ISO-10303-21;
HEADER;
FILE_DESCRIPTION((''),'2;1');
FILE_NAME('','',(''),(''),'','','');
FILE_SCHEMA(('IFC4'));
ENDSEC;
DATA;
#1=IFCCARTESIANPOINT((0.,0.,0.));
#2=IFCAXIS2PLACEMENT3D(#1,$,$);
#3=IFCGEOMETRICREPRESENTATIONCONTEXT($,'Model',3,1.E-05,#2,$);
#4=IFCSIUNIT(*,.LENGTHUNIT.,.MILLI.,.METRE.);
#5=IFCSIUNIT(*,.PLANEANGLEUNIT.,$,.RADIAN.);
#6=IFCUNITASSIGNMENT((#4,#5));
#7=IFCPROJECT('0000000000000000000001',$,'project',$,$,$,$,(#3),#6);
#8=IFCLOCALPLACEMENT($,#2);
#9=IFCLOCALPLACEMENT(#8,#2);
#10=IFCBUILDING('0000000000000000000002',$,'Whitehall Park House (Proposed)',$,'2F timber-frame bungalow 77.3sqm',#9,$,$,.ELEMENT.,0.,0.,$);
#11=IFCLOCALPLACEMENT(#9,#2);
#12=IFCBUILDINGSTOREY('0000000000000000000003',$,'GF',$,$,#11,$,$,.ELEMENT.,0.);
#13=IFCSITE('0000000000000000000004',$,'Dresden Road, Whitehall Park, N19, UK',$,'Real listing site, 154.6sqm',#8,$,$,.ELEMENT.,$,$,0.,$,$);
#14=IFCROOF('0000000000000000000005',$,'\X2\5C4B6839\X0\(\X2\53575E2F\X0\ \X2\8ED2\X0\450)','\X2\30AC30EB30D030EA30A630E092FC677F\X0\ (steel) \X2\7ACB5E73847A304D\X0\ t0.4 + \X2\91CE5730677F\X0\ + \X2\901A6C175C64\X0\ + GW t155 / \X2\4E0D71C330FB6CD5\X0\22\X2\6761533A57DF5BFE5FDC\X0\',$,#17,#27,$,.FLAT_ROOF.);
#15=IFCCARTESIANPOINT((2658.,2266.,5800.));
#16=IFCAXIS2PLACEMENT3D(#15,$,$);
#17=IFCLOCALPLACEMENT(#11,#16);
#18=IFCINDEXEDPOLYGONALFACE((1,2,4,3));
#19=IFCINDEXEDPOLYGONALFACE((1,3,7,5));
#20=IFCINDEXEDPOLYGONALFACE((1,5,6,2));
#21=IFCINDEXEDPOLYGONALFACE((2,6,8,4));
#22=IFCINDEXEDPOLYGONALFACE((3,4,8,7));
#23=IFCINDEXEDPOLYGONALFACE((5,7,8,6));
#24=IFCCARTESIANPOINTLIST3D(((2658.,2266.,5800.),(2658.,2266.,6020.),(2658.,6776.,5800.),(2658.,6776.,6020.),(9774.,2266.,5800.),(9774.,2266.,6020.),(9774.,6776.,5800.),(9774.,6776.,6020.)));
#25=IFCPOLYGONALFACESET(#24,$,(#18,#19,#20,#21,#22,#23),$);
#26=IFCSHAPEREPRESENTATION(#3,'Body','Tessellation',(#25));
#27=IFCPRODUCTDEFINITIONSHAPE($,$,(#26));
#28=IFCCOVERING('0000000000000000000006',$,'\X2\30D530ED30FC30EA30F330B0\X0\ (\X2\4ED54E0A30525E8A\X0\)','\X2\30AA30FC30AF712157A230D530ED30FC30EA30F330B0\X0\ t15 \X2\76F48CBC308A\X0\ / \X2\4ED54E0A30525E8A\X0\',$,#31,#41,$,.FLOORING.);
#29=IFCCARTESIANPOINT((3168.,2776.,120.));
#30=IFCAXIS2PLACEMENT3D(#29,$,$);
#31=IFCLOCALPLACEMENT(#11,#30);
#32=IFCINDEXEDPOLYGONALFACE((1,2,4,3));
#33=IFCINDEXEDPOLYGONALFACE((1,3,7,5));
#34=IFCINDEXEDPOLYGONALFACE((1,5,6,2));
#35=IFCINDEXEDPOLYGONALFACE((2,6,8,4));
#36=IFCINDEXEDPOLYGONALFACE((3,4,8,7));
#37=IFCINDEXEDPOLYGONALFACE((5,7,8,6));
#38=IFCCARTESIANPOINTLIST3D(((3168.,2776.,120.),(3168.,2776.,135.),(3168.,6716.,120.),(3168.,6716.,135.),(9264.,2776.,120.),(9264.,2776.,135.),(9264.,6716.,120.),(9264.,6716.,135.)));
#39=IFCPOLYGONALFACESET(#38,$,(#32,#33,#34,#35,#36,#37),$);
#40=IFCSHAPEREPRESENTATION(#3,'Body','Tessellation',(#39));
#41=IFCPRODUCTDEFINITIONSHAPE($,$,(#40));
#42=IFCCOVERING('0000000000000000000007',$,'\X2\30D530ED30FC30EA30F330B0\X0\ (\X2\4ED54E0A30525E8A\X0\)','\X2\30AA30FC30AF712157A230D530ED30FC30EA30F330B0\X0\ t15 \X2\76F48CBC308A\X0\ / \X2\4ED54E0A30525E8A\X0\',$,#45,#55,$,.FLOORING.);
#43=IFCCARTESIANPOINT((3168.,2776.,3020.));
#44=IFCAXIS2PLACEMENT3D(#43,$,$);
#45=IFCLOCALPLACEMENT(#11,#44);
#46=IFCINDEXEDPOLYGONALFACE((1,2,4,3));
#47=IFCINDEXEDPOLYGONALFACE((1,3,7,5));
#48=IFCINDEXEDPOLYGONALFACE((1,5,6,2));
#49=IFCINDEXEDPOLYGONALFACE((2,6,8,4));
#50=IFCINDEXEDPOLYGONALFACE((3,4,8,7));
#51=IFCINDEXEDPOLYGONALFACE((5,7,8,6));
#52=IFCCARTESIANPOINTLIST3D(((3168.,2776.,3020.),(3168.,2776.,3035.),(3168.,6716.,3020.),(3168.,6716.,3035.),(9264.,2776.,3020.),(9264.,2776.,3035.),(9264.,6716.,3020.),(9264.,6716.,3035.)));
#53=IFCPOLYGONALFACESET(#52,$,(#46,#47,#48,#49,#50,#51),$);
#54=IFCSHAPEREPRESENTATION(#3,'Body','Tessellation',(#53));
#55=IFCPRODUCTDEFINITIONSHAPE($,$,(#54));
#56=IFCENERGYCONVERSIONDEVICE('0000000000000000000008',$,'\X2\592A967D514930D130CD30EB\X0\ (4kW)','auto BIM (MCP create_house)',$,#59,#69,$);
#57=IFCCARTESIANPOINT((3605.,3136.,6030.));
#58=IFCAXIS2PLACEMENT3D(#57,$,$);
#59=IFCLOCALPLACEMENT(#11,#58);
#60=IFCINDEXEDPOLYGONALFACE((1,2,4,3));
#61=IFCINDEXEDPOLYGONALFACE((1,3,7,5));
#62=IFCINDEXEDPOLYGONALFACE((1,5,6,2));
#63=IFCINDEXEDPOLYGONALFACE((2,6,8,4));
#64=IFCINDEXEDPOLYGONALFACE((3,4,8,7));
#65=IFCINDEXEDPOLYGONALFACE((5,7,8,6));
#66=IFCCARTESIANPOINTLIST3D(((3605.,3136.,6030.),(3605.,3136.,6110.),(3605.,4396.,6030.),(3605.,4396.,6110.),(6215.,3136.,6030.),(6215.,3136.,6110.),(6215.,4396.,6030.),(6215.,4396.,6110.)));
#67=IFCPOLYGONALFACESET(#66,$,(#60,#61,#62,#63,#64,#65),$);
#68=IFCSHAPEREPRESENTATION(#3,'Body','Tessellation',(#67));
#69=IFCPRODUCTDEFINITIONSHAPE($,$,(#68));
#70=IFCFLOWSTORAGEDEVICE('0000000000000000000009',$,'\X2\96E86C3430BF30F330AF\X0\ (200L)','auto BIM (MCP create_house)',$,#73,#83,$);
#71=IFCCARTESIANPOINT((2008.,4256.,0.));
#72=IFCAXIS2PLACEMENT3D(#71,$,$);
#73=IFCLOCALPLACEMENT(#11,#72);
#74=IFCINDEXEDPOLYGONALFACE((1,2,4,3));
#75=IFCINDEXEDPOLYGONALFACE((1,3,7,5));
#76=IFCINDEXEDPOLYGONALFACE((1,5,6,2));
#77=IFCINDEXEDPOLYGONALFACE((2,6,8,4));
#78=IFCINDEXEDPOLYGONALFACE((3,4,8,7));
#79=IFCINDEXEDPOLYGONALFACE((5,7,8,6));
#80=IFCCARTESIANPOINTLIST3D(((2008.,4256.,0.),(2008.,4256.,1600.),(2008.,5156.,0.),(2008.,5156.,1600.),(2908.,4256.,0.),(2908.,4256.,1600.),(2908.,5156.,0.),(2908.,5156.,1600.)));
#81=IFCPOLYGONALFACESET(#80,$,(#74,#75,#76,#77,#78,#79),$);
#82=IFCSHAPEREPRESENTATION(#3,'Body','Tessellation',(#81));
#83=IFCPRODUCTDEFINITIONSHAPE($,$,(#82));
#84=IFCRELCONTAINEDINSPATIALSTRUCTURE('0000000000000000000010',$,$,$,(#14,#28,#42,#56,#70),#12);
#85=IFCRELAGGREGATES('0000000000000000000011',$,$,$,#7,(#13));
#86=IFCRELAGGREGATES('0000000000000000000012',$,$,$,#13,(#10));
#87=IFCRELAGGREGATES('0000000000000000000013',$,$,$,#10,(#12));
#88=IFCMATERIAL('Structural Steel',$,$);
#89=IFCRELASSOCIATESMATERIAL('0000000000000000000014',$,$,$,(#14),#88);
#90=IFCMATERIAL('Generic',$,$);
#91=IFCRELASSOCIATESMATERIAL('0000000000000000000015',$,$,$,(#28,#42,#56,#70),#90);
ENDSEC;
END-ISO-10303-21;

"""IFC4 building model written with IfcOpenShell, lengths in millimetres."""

from ifc_helpers import new_model, si_unit, frame, frame_2d, origin, place, context, project, spatial, rectangle, extrude, material, element, save


model = new_model("IFC4")

# Units and contexts
model_context = context("Model", 3, precision=1e-05, world=origin())
ifc_project = project(units=[si_unit("LENGTHUNIT", "METRE", prefix="MILLI"), si_unit("PLANEANGLEUNIT", "RADIAN")], contexts=[model_context])

# Site, building, storey
site_placement = place(None, origin())
site = spatial("IfcSite", under=ifc_project, at=site_placement, Name="Dresden Road, Whitehall Park, N19, UK", ObjectType="Real listing site, 154.6sqm", CompositionType="ELEMENT", RefElevation=0.0)
building_placement = place(site_placement, origin())
building = spatial("IfcBuilding", under=site, at=building_placement, Name="Whitehall Park House (Proposed)", ObjectType="2F timber-frame bungalow 77.3sqm", CompositionType="ELEMENT", ElevationOfRefHeight=0.0, ElevationOfTerrain=0.0)
storey_placement = place(building_placement, origin())
storey = spatial("IfcBuildingStorey", under=building, at=storey_placement, Name="GF", CompositionType="ELEMENT", Elevation=0.0)

# Roof
ifc_material_1 = material(Name="Structural Steel")
for number, where, name in (
    (1, (2658.0, 2266.0, 5800.0), "屋根(南帯 軒450)"),
):
    element("IfcRoof", number, at=place(storey_placement, frame(where)), inside=storey, material=ifc_material_1, Name=name, Description="ガルバリウム鋼板 (steel) 立平葺き t0.4 + 野地板 + 通気層 + GW t155 / 不燃・法22条区域対応", PredefinedType="FLAT_ROOF", context=model_context, shape_type="SweptSolid", body=[
        extrude(rectangle(XDim=7116.0, YDim=4510.0, at=frame_2d((3558.0, 2255.0))), frame((2658.0, 2266.0, 5800.0)), (0.0, 0.0, 1.0), 220.0),
    ])

# Coverings
ifc_material_2 = material(Name="Generic")
covering_1_placement = place(storey_placement, frame((3168.0, 2776.0, 120.0)))
element("IfcCovering", 2, at=covering_1_placement, inside=storey, material=ifc_material_2, Name="フローリング (仕上げ床)", Description="オーク無垢フローリング t15 直貼り / 仕上げ床", PredefinedType="FLOORING", context=model_context, shape_type="SweptSolid", body=[
    extrude(rectangle(XDim=6096.0, YDim=3940.0, at=frame_2d((3048.0, 1970.0))), frame((3168.0, 2776.0, 120.0)), (0.0, 0.0, 1.0), 15.0),
])
covering_2_placement = place(storey_placement, frame((3168.0, 2776.0, 3020.0)))
element("IfcCovering", 3, at=covering_2_placement, inside=storey, material=ifc_material_2, Name="フローリング (仕上げ床)", Description="オーク無垢フローリング t15 直貼り / 仕上げ床", PredefinedType="FLOORING", context=model_context, shape_type="SweptSolid", body=[
    extrude(rectangle(XDim=6096.0, YDim=3940.0, at=frame_2d((3048.0, 1970.0))), frame((3168.0, 2776.0, 3020.0)), (0.0, 0.0, 1.0), 15.0),
])

# Energy conversion device
energy_conversion_device_placement = place(storey_placement, frame((3605.0, 3136.0, 6030.0)))
element("IfcEnergyConversionDevice", 4, at=energy_conversion_device_placement, inside=storey, material=ifc_material_2, Name="太陽光パネル (4kW)", Description="auto BIM (MCP create_house)", context=model_context, shape_type="SweptSolid", body=[
    extrude(rectangle(XDim=2610.0, YDim=1260.0, at=frame_2d((1305.0, 630.0))), frame((3605.0, 3136.0, 6030.0)), (0.0, 0.0, 1.0), 80.0),
])

# Flow storage device
flow_storage_device_placement = place(storey_placement, frame((2008.0, 4256.0, 0.0)))
element("IfcFlowStorageDevice", 5, at=flow_storage_device_placement, inside=storey, material=ifc_material_2, Name="雨水タンク (200L)", Description="auto BIM (MCP create_house)", context=model_context, shape_type="SweptSolid", body=[
    extrude(rectangle(XDim=900.0, YDim=900.0, at=frame_2d((450.0, 450.0))), frame((2008.0, 4256.0, 0.0)), (0.0, 0.0, 1.0), 1600.0),
])

save(model, "model.ifc")
